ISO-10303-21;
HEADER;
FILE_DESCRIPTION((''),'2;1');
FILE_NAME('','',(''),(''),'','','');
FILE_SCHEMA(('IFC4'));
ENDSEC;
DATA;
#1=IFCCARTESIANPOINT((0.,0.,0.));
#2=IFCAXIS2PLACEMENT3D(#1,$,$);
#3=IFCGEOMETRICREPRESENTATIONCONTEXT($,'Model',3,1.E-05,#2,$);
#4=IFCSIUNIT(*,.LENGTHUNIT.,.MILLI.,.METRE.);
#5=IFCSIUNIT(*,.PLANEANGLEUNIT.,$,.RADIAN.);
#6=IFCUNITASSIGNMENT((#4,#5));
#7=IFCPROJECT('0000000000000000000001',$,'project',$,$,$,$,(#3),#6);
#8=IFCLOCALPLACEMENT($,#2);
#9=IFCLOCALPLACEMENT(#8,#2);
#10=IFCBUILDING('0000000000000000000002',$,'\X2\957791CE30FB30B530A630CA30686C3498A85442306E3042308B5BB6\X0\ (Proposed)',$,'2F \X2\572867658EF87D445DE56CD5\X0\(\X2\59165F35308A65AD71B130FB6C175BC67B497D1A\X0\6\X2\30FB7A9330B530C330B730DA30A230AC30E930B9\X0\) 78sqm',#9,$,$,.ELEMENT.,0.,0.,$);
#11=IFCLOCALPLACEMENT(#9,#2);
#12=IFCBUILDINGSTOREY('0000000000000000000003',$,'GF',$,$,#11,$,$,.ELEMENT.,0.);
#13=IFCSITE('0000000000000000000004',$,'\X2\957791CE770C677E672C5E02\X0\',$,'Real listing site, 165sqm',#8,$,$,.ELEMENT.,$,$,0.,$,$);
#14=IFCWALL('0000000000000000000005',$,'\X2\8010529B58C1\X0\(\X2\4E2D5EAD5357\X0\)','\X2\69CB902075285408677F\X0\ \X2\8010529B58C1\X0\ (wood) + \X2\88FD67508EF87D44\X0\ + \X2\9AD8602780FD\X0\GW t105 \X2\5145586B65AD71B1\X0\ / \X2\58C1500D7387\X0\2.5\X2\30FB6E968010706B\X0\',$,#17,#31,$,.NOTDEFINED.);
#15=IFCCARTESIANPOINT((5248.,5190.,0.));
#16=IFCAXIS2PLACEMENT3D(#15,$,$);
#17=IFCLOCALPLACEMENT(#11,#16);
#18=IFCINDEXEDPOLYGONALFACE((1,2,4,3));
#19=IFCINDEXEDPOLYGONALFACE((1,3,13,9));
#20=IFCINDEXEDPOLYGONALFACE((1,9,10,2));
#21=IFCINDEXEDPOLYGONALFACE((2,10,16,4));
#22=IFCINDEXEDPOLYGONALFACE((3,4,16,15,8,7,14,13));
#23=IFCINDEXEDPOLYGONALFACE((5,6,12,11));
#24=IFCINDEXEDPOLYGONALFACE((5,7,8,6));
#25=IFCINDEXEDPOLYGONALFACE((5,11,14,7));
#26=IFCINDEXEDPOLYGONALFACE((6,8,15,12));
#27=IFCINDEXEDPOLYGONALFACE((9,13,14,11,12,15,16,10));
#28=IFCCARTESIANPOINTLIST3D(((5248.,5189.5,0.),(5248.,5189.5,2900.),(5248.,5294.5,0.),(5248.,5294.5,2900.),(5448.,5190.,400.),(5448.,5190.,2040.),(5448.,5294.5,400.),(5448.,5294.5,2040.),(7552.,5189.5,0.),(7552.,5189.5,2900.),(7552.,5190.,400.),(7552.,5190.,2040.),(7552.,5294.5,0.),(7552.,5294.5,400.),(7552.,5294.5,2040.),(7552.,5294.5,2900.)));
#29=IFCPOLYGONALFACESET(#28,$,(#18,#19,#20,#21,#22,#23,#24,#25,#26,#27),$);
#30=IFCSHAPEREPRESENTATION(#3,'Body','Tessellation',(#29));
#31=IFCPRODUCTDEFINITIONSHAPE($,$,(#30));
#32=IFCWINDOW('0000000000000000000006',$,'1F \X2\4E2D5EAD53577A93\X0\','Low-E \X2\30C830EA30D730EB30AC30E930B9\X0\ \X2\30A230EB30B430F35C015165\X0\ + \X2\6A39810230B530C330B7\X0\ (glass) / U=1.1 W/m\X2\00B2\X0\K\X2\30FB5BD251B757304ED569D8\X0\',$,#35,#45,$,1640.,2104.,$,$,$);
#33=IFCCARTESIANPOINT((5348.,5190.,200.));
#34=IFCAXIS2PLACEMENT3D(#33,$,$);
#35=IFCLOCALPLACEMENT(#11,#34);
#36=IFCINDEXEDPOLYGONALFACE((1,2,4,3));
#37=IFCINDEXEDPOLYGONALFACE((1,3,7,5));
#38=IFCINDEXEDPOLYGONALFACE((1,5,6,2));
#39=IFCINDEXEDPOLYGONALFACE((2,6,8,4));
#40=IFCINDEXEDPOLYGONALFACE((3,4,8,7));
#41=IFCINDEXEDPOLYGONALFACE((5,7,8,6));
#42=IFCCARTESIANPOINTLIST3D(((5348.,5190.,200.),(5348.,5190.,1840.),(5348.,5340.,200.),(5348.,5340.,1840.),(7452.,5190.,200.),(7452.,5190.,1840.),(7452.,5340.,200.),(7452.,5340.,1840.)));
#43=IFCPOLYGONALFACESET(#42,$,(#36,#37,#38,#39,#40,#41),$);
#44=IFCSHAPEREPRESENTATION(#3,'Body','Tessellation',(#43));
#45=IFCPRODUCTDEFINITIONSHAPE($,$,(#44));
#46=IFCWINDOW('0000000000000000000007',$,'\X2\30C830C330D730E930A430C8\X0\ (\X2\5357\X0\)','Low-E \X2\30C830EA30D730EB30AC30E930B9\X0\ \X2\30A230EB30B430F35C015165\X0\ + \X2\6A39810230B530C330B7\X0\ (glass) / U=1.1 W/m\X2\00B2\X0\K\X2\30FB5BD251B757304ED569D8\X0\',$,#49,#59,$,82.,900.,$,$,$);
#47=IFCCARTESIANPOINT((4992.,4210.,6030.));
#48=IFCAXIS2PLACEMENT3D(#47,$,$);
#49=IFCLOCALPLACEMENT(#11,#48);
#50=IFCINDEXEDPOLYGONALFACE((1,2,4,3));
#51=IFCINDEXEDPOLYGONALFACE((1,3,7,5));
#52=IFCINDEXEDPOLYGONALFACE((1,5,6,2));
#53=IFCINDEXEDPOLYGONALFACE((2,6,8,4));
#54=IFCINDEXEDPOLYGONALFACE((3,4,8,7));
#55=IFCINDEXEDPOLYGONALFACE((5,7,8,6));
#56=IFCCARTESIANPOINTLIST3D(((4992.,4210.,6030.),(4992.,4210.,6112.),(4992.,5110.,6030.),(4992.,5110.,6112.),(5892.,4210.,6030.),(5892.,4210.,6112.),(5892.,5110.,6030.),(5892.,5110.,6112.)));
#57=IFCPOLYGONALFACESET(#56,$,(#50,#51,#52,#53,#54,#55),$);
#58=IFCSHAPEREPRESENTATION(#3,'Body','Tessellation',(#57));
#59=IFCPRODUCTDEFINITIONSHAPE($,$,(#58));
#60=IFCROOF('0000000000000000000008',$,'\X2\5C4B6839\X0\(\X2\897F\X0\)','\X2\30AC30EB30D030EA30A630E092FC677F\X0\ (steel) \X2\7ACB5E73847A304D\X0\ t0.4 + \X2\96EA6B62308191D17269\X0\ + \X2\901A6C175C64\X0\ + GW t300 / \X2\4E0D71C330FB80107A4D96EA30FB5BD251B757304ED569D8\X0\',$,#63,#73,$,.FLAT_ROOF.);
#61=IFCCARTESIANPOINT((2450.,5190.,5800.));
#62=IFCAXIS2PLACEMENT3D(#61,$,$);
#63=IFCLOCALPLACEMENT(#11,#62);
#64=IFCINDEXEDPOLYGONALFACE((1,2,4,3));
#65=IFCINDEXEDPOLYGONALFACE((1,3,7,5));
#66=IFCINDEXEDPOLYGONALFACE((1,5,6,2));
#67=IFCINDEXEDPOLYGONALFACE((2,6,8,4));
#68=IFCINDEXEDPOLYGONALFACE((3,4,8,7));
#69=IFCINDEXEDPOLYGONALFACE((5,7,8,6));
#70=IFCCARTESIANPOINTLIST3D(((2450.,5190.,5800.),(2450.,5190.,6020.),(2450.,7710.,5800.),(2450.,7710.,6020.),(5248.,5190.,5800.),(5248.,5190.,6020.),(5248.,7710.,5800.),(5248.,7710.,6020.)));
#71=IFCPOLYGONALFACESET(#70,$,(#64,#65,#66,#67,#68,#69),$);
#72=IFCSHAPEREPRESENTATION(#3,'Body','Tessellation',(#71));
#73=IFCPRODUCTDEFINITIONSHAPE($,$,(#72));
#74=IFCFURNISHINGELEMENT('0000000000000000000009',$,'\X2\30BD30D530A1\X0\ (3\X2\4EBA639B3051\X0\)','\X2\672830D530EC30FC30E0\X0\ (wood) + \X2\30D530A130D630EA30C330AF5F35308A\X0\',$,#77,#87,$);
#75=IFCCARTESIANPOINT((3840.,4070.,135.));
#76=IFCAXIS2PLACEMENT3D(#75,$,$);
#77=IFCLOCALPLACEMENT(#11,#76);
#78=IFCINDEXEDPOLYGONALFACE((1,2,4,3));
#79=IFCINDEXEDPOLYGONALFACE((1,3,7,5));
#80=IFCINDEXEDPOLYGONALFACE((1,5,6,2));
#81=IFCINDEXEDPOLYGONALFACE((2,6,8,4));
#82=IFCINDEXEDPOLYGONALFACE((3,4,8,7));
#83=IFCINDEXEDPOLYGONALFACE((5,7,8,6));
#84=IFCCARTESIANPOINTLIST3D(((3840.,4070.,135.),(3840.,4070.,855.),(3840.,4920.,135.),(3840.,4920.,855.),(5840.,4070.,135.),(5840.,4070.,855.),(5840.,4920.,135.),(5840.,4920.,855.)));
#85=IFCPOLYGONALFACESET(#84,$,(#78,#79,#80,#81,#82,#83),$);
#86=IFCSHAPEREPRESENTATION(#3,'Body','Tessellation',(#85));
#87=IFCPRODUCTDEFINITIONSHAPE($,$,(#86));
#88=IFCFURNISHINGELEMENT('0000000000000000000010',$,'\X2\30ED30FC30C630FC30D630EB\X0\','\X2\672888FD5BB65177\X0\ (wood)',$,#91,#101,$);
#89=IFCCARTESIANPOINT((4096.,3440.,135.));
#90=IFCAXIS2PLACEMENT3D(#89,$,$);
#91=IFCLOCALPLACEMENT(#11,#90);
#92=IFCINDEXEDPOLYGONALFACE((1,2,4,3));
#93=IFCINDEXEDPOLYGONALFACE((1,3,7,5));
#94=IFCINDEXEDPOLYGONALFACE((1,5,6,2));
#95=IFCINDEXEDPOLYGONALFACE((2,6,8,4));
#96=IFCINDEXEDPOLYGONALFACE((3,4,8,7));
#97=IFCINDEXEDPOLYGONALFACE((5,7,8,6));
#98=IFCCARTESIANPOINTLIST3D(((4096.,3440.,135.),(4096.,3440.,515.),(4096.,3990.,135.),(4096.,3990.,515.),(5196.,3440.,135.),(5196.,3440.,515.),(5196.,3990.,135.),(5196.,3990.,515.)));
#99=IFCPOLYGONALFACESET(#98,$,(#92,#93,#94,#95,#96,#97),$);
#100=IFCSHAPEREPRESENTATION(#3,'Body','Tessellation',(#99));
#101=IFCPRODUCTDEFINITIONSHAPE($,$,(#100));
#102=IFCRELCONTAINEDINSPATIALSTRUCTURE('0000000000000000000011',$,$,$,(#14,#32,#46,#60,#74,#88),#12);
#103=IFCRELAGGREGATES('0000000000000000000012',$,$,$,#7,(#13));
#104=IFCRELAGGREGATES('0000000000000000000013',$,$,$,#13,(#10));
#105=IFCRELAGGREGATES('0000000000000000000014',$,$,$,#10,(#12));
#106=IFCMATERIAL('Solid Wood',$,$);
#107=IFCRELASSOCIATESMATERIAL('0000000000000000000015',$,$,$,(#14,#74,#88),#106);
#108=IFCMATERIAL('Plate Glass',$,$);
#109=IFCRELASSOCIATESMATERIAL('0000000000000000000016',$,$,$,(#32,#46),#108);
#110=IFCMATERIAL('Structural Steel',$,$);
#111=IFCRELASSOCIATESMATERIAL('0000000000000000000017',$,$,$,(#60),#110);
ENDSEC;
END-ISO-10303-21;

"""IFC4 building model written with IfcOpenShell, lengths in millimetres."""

from ifc_helpers import new_model, si_unit, frame, frame_2d, origin, place, context, project, spatial, rectangle, extrude, material, element, fill, save


model = new_model("IFC4")

# Units and contexts
model_context = context("Model", 3, precision=1e-05, world=origin())
ifc_project = project(units=[si_unit("LENGTHUNIT", "METRE", prefix="MILLI"), si_unit("PLANEANGLEUNIT", "RADIAN")], contexts=[model_context])

# Site, building, storey
site_placement = place(None, origin())
site = spatial("IfcSite", under=ifc_project, at=site_placement, Name="長野県松本市", ObjectType="Real listing site, 165sqm", CompositionType="ELEMENT", RefElevation=0.0)
building_placement = place(site_placement, origin())
building = spatial("IfcBuilding", under=site, at=building_placement, Name="長野・サウナと水風呂のある家 (Proposed)", ObjectType="2F 在来軸組工法(外張り断熱・気密等級6・窓サッシペアガラス) 78sqm", CompositionType="ELEMENT", ElevationOfRefHeight=0.0, ElevationOfTerrain=0.0)
storey_placement = place(building_placement, origin())
storey = spatial("IfcBuildingStorey", under=building, at=storey_placement, Name="GF", CompositionType="ELEMENT", Elevation=0.0)

# Shared definitions
ifc_material_1 = material(Name="Solid Wood")

# Wall, opening, window
wall_1_placement = place(storey_placement, frame((5248.0, 5190.0, 0.0)))
wall_1 = element("IfcWall", 1, at=wall_1_placement, inside=storey, material=ifc_material_1, Name="耐力壁(中庭南)", Description="構造用合板 耐力壁 (wood) + 製材軸組 + 高性能GW t105 充填断熱 / 壁倍率2.5・準耐火", PredefinedType="NOTDEFINED", context=model_context, shape_type="SweptSolid", body=[
    extrude(rectangle(XDim=2304.0, YDim=105.0, at=frame_2d((1152.0, 52.0))), frame((5248.0, 5190.0, 0.0)), (0.0, 0.0, 1.0), 2900.0),
])
opening_placement = place(storey_placement, frame((5348.0, 5190.0, 200.0)))
opening = element("IfcOpeningElement", 2, at=opening_placement, cuts=wall_1, PredefinedType="NOTDEFINED", context=model_context, shape_type="SweptSolid", body=[
    extrude(rectangle(XDim=2104.0, YDim=150.0, at=frame_2d((1052.0, 75.0))), frame((5348.0, 5190.0, 200.0)), (0.0, 0.0, 1.0), 1640.0),
])
ifc_material_2 = material(Name="Plate Glass")
window_1_placement = place(storey_placement, frame((5348.0, 5190.0, 200.0)))
window_1 = element("IfcWindow", 3, at=window_1_placement, inside=storey, material=ifc_material_2, Name="1F 中庭南窓", Description="Low-E トリプルガラス アルゴン封入 + 樹脂サッシ (glass) / U=1.1 W/m²K・寒冷地仕様", OverallHeight=1640.0, OverallWidth=2104.0, context=model_context, shape_type="SweptSolid", body=[
    extrude(rectangle(XDim=2104.0, YDim=150.0, at=frame_2d((1052.0, 75.0))), frame((5348.0, 5190.0, 200.0)), (0.0, 0.0, 1.0), 1640.0),
])
fill(opening, window_1)

# Window
window_2_placement = place(storey_placement, frame((4992.0, 4210.0, 6030.0)))
element("IfcWindow", 4, at=window_2_placement, inside=storey, material=ifc_material_2, Name="トップライト (南)", Description="Low-E トリプルガラス アルゴン封入 + 樹脂サッシ (glass) / U=1.1 W/m²K・寒冷地仕様", OverallHeight=82.0, OverallWidth=900.0, context=model_context, shape_type="SweptSolid", body=[
    extrude(rectangle(XDim=900.0, YDim=900.0, at=frame_2d((450.0, 450.0))), frame((4992.0, 4210.0, 6030.0)), (0.0, 0.0, 1.0), 82.0),
])

# Roof
ifc_material_3 = material(Name="Structural Steel")
for number, where, name in (
    (5, (2450.0, 5190.0, 5800.0), "屋根(西)"),
):
    element("IfcRoof", number, at=place(storey_placement, frame(where)), inside=storey, material=ifc_material_3, Name=name, Description="ガルバリウム鋼板 (steel) 立平葺き t0.4 + 雪止め金物 + 通気層 + GW t300 / 不燃・耐積雪・寒冷地仕様", PredefinedType="FLAT_ROOF", context=model_context, shape_type="SweptSolid", body=[
        extrude(rectangle(XDim=2798.0, YDim=2520.0, at=frame_2d((1399.0, 1260.0))), frame((2450.0, 5190.0, 5800.0)), (0.0, 0.0, 1.0), 220.0),
    ])

# Furnishing elements
furnishing_1_placement = place(storey_placement, frame((3840.0, 4070.0, 135.0)))
element("IfcFurnishingElement", 6, at=furnishing_1_placement, inside=storey, material=ifc_material_1, Name="ソファ (3人掛け)", Description="木フレーム (wood) + ファブリック張り", context=model_context, shape_type="SweptSolid", body=[
    extrude(rectangle(XDim=2000.0, YDim=850.0, at=frame_2d((1000.0, 425.0))), frame((3840.0, 4070.0, 135.0)), (0.0, 0.0, 1.0), 720.0),
])
furnishing_2_placement = place(storey_placement, frame((4096.0, 3440.0, 135.0)))
element("IfcFurnishingElement", 7, at=furnishing_2_placement, inside=storey, material=ifc_material_1, Name="ローテーブル", Description="木製家具 (wood)", context=model_context, shape_type="SweptSolid", body=[
    extrude(rectangle(XDim=1100.0, YDim=550.0, at=frame_2d((550.0, 275.0))), frame((4096.0, 3440.0, 135.0)), (0.0, 0.0, 1.0), 380.0),
])

save(model, "model.ifc")
